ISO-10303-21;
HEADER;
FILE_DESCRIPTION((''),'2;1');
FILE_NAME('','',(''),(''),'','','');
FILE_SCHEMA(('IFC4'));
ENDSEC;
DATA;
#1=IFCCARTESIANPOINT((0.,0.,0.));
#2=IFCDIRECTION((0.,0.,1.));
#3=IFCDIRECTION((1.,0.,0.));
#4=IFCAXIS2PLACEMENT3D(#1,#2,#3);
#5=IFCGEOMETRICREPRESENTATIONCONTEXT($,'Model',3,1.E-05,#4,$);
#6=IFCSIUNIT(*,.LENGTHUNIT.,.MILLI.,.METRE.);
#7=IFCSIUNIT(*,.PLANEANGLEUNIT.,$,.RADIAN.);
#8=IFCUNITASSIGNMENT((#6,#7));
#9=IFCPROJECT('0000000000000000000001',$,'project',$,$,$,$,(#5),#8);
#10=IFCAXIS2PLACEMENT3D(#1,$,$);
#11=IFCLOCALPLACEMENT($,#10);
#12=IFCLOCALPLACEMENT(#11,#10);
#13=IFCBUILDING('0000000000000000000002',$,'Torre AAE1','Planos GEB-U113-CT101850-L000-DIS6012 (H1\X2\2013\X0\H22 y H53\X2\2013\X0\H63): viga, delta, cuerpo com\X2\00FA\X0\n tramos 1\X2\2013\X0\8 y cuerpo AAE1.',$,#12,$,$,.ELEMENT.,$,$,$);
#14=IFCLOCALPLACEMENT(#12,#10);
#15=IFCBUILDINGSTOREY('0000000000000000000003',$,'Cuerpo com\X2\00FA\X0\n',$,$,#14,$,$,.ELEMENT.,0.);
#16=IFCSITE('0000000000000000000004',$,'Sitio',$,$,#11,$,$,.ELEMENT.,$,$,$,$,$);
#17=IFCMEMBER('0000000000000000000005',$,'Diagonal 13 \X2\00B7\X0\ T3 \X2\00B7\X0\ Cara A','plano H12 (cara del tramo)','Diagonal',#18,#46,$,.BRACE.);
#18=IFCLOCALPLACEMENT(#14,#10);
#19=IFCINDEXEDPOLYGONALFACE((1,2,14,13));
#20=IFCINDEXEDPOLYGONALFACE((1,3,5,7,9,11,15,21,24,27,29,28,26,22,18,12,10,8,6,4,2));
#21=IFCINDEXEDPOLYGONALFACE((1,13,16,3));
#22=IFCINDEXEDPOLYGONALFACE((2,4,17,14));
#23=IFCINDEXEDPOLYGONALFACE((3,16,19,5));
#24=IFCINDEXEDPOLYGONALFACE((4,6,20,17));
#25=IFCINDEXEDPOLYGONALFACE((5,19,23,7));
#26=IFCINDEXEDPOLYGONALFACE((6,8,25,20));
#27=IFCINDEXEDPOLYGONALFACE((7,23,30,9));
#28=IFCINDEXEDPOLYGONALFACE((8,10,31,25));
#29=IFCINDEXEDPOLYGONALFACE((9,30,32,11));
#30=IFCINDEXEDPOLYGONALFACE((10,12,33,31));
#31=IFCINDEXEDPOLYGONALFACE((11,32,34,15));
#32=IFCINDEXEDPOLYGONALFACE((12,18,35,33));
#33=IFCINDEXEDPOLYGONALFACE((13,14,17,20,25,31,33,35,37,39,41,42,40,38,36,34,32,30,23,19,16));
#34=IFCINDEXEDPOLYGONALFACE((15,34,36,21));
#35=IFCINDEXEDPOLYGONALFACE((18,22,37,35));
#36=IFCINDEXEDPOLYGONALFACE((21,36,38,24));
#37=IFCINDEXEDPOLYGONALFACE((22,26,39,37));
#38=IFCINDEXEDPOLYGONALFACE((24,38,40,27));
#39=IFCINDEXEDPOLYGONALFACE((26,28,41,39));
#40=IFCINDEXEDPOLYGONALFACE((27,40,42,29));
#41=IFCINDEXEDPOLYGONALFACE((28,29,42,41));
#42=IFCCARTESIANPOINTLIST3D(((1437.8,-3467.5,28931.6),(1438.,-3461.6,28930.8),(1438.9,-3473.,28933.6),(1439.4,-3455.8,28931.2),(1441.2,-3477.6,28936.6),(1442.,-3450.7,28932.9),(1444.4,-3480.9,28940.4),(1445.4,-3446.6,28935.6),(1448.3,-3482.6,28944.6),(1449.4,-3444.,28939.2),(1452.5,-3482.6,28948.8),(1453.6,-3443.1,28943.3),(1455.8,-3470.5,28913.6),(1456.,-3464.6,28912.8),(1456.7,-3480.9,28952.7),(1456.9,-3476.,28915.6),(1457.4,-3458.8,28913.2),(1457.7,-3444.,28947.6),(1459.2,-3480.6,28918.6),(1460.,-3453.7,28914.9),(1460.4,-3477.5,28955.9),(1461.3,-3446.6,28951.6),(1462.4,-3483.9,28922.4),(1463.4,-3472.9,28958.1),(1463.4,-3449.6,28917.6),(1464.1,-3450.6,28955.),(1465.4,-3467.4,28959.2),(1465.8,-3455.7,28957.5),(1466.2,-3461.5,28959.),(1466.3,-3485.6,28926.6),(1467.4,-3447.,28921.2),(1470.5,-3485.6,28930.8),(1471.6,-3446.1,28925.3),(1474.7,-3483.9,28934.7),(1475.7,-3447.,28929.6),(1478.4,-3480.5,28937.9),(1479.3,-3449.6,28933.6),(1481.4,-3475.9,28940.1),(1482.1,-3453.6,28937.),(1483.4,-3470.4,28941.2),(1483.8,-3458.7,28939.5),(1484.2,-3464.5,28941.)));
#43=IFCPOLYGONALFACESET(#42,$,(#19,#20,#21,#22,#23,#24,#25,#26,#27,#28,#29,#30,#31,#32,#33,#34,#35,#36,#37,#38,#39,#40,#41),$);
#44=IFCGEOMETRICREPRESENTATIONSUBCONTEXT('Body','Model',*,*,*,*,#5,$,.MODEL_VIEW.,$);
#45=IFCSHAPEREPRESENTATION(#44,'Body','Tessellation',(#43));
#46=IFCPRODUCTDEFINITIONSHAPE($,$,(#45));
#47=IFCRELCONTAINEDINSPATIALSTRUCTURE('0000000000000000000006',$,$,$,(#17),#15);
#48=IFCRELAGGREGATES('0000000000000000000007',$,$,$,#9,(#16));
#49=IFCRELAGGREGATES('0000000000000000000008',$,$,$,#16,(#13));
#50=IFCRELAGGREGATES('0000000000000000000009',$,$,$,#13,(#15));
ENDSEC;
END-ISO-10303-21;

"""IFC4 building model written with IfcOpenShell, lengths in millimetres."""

from ifc_helpers import new_model, si_unit, frame, origin, origin_with_axes, place, context, subcontext, project, spatial, circle, extrude, element, save


model = new_model("IFC4")

# Units and contexts
model_context = context("Model", 3, precision=1e-05, world=origin_with_axes())
body_context = subcontext(model_context, "Body", "Model", "MODEL_VIEW")
ifc_project = project(units=[si_unit("LENGTHUNIT", "METRE", prefix="MILLI"), si_unit("PLANEANGLEUNIT", "RADIAN")], contexts=[model_context])

# Site, building, storey
site_placement = place(None, origin())
site = spatial("IfcSite", under=ifc_project, at=site_placement, Name="Sitio", CompositionType="ELEMENT")
building_placement = place(site_placement, origin())
building = spatial("IfcBuilding", under=site, at=building_placement, Name="Torre AAE1", Description="Planos GEB-U113-CT101850-L000-DIS6012 (H1–H22 y H53–H63): viga, delta, cuerpo común tramos 1–8 y cuerpo AAE1.", CompositionType="ELEMENT")
storey_placement = place(building_placement, origin())
storey = spatial("IfcBuildingStorey", under=building, at=storey_placement, Name="Cuerpo común", CompositionType="ELEMENT", Elevation=0.0)

# Member
member_1_placement = place(storey_placement, frame((1452.0, -3463.0, 28945.0), z_axis=(0.702247, -0.117041, -0.702247), x_axis=(-0.131084, 0.948273, -0.289129)))
element("IfcMember", 1, at=member_1_placement, inside=storey, Name="Diagonal 13 · T3 · Cara A", Description="plano H12 (cara del tramo)", ObjectType="Diagonal", PredefinedType="BRACE", context=body_context, shape_type="SweptSolid", body=[
    extrude(circle(Radius=20.0), None, (0.0, 0.0, 1.0), 25.6),
])

save(model, "model.ifc")
